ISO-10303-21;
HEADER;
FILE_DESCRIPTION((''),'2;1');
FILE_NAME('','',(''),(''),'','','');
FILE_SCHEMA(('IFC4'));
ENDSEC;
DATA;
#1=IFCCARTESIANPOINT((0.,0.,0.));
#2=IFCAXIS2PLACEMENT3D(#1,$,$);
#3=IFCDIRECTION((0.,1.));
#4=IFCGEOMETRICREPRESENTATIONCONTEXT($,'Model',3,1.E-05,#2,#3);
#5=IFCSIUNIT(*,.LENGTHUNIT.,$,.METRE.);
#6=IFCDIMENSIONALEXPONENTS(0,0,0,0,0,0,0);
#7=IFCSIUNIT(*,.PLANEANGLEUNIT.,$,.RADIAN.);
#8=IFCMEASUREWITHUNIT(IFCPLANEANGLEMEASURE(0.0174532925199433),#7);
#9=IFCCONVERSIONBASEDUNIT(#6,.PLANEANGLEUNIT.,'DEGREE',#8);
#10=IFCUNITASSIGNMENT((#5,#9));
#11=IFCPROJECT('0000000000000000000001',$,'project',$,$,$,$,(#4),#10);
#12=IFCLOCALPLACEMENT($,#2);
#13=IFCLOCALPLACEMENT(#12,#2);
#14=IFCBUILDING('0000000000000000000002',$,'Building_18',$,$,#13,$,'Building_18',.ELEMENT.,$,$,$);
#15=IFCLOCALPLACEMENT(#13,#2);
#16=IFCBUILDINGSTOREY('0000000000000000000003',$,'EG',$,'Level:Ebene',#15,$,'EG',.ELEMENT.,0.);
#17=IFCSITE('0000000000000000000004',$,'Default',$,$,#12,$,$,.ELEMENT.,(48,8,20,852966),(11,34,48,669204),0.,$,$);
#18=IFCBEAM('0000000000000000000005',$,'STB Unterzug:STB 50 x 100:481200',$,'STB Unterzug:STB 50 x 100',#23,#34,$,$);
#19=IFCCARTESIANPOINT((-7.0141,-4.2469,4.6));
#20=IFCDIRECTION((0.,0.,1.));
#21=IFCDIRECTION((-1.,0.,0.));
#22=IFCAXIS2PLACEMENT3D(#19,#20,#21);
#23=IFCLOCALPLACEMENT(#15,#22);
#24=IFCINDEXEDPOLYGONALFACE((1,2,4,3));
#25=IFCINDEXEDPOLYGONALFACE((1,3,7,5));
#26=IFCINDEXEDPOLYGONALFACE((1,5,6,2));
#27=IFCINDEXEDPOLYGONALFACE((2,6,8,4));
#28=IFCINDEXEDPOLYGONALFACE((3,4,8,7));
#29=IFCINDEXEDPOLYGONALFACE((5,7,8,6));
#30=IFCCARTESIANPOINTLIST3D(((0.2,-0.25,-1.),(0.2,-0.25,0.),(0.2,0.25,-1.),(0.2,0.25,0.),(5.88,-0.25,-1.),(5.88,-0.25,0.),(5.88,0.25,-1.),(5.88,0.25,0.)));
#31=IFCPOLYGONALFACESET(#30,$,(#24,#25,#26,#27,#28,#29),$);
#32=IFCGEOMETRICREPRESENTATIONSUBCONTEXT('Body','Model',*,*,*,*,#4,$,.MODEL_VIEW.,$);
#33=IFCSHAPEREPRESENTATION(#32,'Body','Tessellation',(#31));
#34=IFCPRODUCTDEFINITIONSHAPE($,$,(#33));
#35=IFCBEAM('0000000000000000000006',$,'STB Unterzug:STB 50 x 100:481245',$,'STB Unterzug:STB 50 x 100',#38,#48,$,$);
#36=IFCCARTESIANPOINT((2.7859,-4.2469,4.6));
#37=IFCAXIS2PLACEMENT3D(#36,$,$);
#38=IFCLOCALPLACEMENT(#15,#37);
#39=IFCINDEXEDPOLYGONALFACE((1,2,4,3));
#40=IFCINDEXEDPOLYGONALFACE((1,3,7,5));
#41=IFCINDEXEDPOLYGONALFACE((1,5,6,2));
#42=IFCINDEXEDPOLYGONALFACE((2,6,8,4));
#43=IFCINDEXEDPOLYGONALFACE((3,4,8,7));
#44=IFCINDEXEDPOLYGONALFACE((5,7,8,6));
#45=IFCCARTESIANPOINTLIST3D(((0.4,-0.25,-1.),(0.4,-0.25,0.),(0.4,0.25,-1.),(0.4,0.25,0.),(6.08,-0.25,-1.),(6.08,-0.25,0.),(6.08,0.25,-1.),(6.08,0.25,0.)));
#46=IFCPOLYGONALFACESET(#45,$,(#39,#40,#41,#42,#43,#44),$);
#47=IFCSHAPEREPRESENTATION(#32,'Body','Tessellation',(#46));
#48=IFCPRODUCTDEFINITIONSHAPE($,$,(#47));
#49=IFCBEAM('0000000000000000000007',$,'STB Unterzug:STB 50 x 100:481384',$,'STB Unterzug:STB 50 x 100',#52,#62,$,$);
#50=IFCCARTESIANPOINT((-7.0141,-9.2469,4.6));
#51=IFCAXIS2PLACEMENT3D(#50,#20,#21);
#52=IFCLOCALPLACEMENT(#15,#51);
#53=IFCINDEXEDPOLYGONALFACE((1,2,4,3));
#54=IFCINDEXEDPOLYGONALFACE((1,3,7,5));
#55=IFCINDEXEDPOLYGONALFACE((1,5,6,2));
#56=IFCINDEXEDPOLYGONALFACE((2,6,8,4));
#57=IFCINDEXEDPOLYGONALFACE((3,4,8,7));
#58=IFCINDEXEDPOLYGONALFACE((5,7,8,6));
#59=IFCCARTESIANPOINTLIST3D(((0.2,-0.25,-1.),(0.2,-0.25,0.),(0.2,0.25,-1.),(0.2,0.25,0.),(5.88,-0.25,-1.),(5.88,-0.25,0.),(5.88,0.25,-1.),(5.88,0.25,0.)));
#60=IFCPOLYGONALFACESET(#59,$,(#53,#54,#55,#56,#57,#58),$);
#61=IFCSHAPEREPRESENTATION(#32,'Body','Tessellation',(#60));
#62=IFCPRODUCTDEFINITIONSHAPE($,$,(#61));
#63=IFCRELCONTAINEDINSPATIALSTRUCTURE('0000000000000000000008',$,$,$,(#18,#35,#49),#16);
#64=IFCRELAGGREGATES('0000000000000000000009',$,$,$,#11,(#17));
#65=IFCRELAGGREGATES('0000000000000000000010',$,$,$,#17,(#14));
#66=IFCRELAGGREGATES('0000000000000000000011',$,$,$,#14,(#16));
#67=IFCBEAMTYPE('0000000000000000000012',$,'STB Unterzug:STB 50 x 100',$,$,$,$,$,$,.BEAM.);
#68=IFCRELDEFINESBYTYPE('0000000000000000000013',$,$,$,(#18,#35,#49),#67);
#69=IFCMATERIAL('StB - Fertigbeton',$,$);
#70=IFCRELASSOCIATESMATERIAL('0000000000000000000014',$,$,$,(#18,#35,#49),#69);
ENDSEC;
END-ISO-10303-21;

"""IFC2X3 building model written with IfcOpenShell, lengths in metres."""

from ifc_helpers import new_model, entity, si_unit, converted_unit, direction, frame, origin, origin_2d_with_axis, place, context, subcontext, project, spatial, rectangle, extrude, material, type_object, element, save


model = new_model("IFC2X3")

# Units and contexts
model_context = context("Model", 3, precision=1e-05, world=origin(), true_north=direction((0.0, 1.0)))
body_context = subcontext(model_context, "Body", "Model", "MODEL_VIEW")
ifc_project = project(units=[si_unit("LENGTHUNIT", "METRE"), converted_unit("PLANEANGLEUNIT", "DEGREE", entity("IfcPlaneAngleMeasure", 0.0174532925199433), si_unit("PLANEANGLEUNIT", "RADIAN"), dimensions=[0, 0, 0, 0, 0, 0, 0])], contexts=[model_context])

# Site, building, storey
site_placement = place(None, origin())
site = spatial("IfcSite", under=ifc_project, at=site_placement, Name="Default", CompositionType="ELEMENT", RefLatitude=(48, 8, 20, 852966), RefLongitude=(11, 34, 48, 669204), RefElevation=0.0)
building_placement = place(site_placement, origin())
building = spatial("IfcBuilding", under=site, at=building_placement, Name="Building_18", LongName="Building_18", CompositionType="ELEMENT")
storey_placement = place(building_placement, origin())
storey = spatial("IfcBuildingStorey", under=building, at=storey_placement, Name="EG", ObjectType="Level:Ebene", LongName="EG", CompositionType="ELEMENT", Elevation=0.0)

# Beams
ifc_material_1 = material(Name="StB - Fertigbeton")
beam_type = type_object("IfcBeamType", Name="STB Unterzug:STB 50 x 100", PredefinedType="BEAM")
beam_1_placement = place(storey_placement, frame((-7.0141, -4.2469, 4.6), z_axis=(0.0, 0.0, 1.0), x_axis=(-1.0, 0.0, 0.0)))
element("IfcBeam", 1, at=beam_1_placement, inside=storey, type_object=beam_type, material=ifc_material_1, Name="STB Unterzug:STB 50 x 100:481200", ObjectType="STB Unterzug:STB 50 x 100", context=body_context, shape_type="SweptSolid", body=[
    extrude(rectangle(XDim=1.0, YDim=0.5, at=origin_2d_with_axis()), frame((0.2, 0.0, -0.5), z_axis=(1.0, 0.0, 0.0), x_axis=(0.0, 0.0, -1.0)), (0.0, 0.0, 1.0), 5.68),
])
beam_2_placement = place(storey_placement, frame((2.7859, -4.2469, 4.6)))
element("IfcBeam", 2, at=beam_2_placement, inside=storey, type_object=beam_type, material=ifc_material_1, Name="STB Unterzug:STB 50 x 100:481245", ObjectType="STB Unterzug:STB 50 x 100", context=body_context, shape_type="SweptSolid", body=[
    extrude(rectangle(XDim=1.0, YDim=0.5, at=origin_2d_with_axis()), frame((0.4, 0.0, -0.5), z_axis=(1.0, 0.0, 0.0), x_axis=(0.0, 0.0, -1.0)), (0.0, 0.0, 1.0), 5.68),
])
beam_3_placement = place(storey_placement, frame((-7.0141, -9.2469, 4.6), z_axis=(0.0, 0.0, 1.0), x_axis=(-1.0, 0.0, 0.0)))
element("IfcBeam", 3, at=beam_3_placement, inside=storey, type_object=beam_type, material=ifc_material_1, Name="STB Unterzug:STB 50 x 100:481384", ObjectType="STB Unterzug:STB 50 x 100", context=body_context, shape_type="SweptSolid", body=[
    extrude(rectangle(XDim=1.0, YDim=0.5, at=origin_2d_with_axis()), frame((0.2, 0.0, -0.5), z_axis=(1.0, 0.0, 0.0), x_axis=(0.0, 0.0, -1.0)), (0.0, 0.0, 1.0), 5.68),
])

save(model, "model.ifc")
